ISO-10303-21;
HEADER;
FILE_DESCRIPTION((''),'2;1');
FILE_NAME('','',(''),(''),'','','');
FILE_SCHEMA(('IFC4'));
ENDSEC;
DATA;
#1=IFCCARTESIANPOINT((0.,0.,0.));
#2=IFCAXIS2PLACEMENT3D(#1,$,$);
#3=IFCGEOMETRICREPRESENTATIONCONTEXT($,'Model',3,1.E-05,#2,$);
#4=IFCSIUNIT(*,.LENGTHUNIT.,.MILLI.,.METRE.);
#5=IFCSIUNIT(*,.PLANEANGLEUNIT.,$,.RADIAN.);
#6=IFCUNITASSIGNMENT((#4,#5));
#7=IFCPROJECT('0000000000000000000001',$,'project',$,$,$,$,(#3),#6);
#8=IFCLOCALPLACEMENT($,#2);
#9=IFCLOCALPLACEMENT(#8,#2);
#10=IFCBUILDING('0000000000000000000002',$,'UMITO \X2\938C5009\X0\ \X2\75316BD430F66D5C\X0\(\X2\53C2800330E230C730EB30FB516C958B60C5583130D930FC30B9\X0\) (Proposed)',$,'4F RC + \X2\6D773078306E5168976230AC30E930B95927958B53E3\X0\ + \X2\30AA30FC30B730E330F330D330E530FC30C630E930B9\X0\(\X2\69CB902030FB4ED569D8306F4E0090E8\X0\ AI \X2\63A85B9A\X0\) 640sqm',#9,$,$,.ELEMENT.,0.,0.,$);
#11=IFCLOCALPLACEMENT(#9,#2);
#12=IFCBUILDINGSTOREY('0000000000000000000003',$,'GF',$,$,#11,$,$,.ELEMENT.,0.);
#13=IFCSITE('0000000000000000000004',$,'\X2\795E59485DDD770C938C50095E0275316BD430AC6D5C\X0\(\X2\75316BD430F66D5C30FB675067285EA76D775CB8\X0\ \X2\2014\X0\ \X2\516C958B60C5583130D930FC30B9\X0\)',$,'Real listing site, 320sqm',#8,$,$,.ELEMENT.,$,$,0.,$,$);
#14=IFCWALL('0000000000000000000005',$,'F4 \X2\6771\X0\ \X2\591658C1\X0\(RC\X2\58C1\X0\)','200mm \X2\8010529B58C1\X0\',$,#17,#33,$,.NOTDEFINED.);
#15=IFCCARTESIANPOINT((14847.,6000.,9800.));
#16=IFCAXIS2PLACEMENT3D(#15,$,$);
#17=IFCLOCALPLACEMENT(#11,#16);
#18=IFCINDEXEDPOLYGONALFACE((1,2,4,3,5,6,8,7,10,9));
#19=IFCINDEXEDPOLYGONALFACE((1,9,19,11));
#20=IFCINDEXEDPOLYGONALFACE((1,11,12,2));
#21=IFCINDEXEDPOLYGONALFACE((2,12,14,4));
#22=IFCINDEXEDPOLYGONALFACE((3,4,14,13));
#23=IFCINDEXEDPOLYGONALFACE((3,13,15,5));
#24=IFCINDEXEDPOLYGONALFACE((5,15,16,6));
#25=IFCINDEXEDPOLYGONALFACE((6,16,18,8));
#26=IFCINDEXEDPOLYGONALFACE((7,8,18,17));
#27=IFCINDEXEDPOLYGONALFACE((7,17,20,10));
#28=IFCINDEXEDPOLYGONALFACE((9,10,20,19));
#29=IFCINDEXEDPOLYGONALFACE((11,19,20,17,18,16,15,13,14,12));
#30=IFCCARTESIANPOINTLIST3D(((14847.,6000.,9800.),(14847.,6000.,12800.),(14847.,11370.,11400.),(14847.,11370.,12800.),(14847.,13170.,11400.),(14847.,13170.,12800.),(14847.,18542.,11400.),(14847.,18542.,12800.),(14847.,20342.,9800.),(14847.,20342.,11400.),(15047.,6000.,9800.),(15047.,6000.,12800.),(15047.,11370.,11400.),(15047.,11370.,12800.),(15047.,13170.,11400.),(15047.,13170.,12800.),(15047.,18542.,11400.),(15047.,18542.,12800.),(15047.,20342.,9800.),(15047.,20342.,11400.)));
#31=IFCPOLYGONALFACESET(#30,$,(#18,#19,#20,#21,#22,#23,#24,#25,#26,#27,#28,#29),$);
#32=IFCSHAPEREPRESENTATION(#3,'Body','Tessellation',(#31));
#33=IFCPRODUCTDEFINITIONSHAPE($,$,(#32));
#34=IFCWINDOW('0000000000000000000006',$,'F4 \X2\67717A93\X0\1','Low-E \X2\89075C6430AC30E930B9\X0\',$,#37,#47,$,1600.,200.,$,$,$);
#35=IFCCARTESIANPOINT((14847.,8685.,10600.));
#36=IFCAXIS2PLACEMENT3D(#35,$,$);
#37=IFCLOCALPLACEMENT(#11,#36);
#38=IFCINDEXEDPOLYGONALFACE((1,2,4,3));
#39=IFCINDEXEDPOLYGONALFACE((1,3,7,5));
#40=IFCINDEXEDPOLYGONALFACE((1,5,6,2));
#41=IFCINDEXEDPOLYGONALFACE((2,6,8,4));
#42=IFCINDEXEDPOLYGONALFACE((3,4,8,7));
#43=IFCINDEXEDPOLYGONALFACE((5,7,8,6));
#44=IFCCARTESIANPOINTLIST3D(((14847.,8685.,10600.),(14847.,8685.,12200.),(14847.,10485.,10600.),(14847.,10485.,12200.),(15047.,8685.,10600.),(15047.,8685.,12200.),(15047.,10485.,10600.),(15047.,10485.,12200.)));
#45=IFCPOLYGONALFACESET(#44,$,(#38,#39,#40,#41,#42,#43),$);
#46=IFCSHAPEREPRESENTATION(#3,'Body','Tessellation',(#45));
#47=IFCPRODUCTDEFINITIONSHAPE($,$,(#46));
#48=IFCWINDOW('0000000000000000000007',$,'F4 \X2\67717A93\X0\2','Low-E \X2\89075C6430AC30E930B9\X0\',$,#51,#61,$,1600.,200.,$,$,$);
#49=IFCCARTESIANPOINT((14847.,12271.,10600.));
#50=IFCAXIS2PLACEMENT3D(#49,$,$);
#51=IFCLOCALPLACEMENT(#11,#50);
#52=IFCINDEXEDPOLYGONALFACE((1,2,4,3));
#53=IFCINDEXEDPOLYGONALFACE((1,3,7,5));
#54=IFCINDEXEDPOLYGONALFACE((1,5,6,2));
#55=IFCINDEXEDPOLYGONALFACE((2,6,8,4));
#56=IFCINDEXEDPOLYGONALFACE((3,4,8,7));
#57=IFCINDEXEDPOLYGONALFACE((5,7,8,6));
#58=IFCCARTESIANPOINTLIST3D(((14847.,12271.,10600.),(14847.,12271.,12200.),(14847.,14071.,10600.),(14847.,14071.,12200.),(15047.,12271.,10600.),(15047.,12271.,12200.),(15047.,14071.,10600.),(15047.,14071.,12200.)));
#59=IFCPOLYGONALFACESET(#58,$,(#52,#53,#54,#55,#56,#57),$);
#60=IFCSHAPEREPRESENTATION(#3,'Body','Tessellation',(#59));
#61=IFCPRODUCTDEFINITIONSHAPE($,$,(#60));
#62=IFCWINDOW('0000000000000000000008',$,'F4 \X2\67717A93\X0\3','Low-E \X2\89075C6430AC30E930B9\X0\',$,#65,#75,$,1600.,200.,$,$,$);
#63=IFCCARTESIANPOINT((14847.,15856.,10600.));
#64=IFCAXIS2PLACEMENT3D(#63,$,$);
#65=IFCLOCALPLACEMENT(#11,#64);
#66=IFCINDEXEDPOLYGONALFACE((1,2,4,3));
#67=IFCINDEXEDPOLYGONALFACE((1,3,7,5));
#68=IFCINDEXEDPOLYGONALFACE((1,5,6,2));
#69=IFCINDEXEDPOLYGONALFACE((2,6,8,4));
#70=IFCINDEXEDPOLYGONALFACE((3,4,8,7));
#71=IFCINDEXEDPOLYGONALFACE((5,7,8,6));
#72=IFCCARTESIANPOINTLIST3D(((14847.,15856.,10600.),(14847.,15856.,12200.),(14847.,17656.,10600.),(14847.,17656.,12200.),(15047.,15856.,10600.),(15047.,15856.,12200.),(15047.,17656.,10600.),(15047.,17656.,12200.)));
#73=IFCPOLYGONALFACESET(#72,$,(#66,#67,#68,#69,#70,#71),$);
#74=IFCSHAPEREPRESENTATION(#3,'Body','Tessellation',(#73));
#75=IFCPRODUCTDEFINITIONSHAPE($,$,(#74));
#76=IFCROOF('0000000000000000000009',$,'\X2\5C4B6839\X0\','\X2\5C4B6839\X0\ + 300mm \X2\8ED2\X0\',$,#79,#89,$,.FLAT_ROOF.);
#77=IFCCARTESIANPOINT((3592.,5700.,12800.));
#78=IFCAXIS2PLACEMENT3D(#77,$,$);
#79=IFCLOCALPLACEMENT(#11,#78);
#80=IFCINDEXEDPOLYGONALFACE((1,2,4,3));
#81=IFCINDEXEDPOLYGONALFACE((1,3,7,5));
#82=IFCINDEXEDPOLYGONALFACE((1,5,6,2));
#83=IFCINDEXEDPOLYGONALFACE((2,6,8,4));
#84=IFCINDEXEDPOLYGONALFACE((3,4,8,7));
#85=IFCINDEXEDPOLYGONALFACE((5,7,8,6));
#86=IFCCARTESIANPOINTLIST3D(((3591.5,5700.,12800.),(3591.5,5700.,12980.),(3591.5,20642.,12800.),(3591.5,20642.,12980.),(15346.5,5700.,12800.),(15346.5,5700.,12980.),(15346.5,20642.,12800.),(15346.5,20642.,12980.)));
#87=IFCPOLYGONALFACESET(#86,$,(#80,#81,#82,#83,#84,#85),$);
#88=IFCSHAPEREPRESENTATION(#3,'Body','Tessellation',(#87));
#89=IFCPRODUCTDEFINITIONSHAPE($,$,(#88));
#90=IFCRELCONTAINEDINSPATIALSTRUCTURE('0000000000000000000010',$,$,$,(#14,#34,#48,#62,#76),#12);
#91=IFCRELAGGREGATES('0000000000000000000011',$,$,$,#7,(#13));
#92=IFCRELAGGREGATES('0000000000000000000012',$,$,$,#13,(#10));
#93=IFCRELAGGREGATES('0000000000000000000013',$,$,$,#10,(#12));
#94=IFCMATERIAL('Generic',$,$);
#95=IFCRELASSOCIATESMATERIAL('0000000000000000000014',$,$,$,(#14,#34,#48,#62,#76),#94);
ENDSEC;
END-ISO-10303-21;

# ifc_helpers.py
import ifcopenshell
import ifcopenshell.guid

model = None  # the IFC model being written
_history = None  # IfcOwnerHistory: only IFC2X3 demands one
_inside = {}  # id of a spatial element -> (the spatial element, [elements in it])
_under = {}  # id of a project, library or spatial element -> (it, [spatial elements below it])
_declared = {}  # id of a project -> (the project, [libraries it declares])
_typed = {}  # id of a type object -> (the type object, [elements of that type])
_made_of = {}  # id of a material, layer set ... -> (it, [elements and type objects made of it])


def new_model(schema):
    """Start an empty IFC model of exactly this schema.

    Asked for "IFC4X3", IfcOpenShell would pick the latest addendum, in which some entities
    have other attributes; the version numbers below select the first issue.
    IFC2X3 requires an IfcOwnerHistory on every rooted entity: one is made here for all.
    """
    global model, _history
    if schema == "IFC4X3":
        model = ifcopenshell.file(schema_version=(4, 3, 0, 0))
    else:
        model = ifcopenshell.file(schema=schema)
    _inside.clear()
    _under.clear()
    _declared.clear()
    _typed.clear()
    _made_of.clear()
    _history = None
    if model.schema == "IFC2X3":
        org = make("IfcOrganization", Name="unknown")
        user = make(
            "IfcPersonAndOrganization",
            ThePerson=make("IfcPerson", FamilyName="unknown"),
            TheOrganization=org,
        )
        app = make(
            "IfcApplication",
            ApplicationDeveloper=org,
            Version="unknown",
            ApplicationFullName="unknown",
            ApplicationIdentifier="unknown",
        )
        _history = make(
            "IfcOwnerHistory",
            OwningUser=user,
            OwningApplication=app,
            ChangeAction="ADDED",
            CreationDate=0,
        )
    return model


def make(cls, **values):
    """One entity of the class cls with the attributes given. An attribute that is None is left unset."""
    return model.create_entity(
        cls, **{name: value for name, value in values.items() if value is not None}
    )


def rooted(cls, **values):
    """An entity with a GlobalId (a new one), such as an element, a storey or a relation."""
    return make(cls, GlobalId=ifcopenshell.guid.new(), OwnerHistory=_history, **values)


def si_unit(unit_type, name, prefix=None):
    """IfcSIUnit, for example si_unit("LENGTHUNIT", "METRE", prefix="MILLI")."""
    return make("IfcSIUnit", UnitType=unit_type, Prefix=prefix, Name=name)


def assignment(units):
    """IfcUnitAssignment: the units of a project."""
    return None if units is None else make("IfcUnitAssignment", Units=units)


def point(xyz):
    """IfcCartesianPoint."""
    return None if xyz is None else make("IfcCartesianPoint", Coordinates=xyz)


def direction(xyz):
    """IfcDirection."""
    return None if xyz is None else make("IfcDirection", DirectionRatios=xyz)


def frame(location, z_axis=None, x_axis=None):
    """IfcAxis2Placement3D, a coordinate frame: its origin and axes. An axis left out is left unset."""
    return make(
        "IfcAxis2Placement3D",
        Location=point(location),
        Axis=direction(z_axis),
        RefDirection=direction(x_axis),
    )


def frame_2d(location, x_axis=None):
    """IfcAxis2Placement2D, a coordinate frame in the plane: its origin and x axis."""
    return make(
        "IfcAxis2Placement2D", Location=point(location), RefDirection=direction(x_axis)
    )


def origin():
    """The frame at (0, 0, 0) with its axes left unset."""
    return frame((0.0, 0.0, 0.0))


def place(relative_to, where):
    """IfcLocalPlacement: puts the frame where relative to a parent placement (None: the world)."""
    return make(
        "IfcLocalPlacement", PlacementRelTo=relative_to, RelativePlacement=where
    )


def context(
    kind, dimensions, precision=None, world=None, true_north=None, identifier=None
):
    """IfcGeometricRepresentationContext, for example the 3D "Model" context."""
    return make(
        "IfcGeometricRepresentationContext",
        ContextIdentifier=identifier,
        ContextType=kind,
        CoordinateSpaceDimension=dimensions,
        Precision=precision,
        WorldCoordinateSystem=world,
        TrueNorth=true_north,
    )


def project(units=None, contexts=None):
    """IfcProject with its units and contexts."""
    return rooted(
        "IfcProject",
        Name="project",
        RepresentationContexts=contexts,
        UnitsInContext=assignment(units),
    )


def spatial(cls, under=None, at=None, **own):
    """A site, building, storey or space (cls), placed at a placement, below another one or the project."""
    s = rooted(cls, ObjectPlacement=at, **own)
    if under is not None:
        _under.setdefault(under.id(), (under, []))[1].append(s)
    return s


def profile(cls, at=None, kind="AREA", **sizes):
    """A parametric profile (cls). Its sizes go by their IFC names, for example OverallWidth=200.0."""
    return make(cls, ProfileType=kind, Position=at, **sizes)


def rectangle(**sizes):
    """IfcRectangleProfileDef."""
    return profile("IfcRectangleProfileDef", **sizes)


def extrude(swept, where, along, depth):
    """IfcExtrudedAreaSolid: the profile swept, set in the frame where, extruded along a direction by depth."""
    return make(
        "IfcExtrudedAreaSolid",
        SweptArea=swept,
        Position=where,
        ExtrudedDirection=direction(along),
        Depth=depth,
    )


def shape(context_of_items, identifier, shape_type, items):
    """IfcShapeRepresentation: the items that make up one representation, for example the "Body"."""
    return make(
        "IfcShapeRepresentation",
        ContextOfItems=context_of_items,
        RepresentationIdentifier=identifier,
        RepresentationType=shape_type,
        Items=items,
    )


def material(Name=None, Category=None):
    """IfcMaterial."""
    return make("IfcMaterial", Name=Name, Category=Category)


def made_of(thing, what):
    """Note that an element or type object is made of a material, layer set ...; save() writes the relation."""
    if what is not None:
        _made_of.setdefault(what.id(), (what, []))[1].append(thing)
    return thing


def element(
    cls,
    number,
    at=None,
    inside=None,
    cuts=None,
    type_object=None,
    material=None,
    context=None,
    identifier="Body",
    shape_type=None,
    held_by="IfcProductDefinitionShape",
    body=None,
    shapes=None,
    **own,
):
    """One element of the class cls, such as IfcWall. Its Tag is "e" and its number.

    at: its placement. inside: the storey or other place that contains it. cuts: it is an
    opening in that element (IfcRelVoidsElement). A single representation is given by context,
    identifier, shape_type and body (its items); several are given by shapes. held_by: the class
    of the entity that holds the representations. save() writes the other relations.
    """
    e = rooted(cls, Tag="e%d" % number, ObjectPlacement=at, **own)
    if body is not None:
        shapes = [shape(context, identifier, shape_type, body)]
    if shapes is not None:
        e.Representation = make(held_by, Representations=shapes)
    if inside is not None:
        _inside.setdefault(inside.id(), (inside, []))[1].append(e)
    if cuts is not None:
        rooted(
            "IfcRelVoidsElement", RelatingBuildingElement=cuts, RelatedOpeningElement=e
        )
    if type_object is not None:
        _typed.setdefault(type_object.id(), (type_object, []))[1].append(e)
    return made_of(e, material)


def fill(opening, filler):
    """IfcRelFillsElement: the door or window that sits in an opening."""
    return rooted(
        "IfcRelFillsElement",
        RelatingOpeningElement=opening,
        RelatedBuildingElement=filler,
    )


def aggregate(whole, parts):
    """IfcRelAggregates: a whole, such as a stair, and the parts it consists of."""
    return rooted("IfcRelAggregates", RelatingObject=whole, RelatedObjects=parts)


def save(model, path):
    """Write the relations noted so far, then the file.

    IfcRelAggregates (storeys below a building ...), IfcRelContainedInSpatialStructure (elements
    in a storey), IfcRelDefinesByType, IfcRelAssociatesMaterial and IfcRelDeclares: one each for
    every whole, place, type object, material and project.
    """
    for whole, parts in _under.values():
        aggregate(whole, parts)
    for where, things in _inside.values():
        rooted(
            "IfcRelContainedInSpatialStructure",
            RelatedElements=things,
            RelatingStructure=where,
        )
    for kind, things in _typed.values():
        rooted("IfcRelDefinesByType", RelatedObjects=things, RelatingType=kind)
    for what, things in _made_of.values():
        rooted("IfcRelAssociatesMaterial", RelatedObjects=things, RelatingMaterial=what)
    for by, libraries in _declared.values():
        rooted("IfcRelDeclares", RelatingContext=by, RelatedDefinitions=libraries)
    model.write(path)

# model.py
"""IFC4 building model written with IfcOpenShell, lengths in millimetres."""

from ifc_helpers import new_model, si_unit, frame, frame_2d, origin, place, context, project, spatial, rectangle, extrude, material, element, fill, save


model = new_model("IFC4")

# Units and contexts
model_context = context("Model", 3, precision=1e-05, world=origin())
ifc_project = project(units=[si_unit("LENGTHUNIT", "METRE", prefix="MILLI"), si_unit("PLANEANGLEUNIT", "RADIAN")], contexts=[model_context])

# Site, building, storey
site_placement = place(None, origin())
site = spatial("IfcSite", under=ifc_project, at=site_placement, Name="神奈川県鎌倉市由比ガ浜(由比ヶ浜・材木座海岸 — 公開情報ベース)", ObjectType="Real listing site, 320sqm", CompositionType="ELEMENT", RefElevation=0.0)
building_placement = place(site_placement, origin())
building = spatial("IfcBuilding", under=site, at=building_placement, Name="UMITO 鎌倉 由比ヶ浜(参考モデル・公開情報ベース) (Proposed)", ObjectType="4F RC + 海への全面ガラス大開口 + オーシャンビューテラス(構造・仕様は一部 AI 推定) 640sqm", CompositionType="ELEMENT", ElevationOfRefHeight=0.0, ElevationOfTerrain=0.0)
storey_placement = place(building_placement, origin())
storey = spatial("IfcBuildingStorey", under=building, at=storey_placement, Name="GF", CompositionType="ELEMENT", Elevation=0.0)

# Shared definitions
ifc_material_1 = material(Name="Generic")

# Wall, openings, windows
wall_1_placement = place(storey_placement, frame((14847.0, 6000.0, 9800.0)))
wall_1 = element("IfcWall", 1, at=wall_1_placement, inside=storey, material=ifc_material_1, Name="F4 東 外壁(RC壁)", Description="200mm 耐力壁", PredefinedType="NOTDEFINED", context=model_context, shape_type="SweptSolid", body=[
    extrude(rectangle(XDim=200.0, YDim=14342.0, at=frame_2d((100.0, 7171.0))), frame((14847.0, 6000.0, 9800.0)), (0.0, 0.0, 1.0), 3000.0),
])
opening_1_placement = place(storey_placement, frame((14847.0, 8685.0, 10600.0)))
opening_1 = element("IfcOpeningElement", 2, at=opening_1_placement, cuts=wall_1, PredefinedType="NOTDEFINED", context=model_context, shape_type="SweptSolid", body=[
    extrude(rectangle(XDim=200.0, YDim=1800.0, at=frame_2d((100.0, 900.0))), frame((14847.0, 8685.0, 10600.0)), (0.0, 0.0, 1.0), 1600.0),
])
opening_2_placement = place(storey_placement, frame((14847.0, 12271.0, 10600.0)))
opening_2 = element("IfcOpeningElement", 3, at=opening_2_placement, cuts=wall_1, PredefinedType="NOTDEFINED", context=model_context, shape_type="SweptSolid", body=[
    extrude(rectangle(XDim=200.0, YDim=1800.0, at=frame_2d((100.0, 900.0))), frame((14847.0, 12271.0, 10600.0)), (0.0, 0.0, 1.0), 1600.0),
])
opening_3_placement = place(storey_placement, frame((14847.0, 15856.0, 10600.0)))
opening_3 = element("IfcOpeningElement", 4, at=opening_3_placement, cuts=wall_1, PredefinedType="NOTDEFINED", context=model_context, shape_type="SweptSolid", body=[
    extrude(rectangle(XDim=200.0, YDim=1800.0, at=frame_2d((100.0, 900.0))), frame((14847.0, 15856.0, 10600.0)), (0.0, 0.0, 1.0), 1600.0),
])
window_1_placement = place(storey_placement, frame((14847.0, 8685.0, 10600.0)))
window_1 = element("IfcWindow", 5, at=window_1_placement, inside=storey, material=ifc_material_1, Name="F4 東窓1", Description="Low-E 複層ガラス", OverallHeight=1600.0, OverallWidth=200.0, context=model_context, shape_type="SweptSolid", body=[
    extrude(rectangle(XDim=200.0, YDim=1800.0, at=frame_2d((100.0, 900.0))), frame((14847.0, 8685.0, 10600.0)), (0.0, 0.0, 1.0), 1600.0),
])
fill(opening_1, window_1)
window_2_placement = place(storey_placement, frame((14847.0, 12271.0, 10600.0)))
window_2 = element("IfcWindow", 6, at=window_2_placement, inside=storey, material=ifc_material_1, Name="F4 東窓2", Description="Low-E 複層ガラス", OverallHeight=1600.0, OverallWidth=200.0, context=model_context, shape_type="SweptSolid", body=[
    extrude(rectangle(XDim=200.0, YDim=1800.0, at=frame_2d((100.0, 900.0))), frame((14847.0, 12271.0, 10600.0)), (0.0, 0.0, 1.0), 1600.0),
])
fill(opening_2, window_2)
window_3_placement = place(storey_placement, frame((14847.0, 15856.0, 10600.0)))
window_3 = element("IfcWindow", 7, at=window_3_placement, inside=storey, material=ifc_material_1, Name="F4 東窓3", Description="Low-E 複層ガラス", OverallHeight=1600.0, OverallWidth=200.0, context=model_context, shape_type="SweptSolid", body=[
    extrude(rectangle(XDim=200.0, YDim=1800.0, at=frame_2d((100.0, 900.0))), frame((14847.0, 15856.0, 10600.0)), (0.0, 0.0, 1.0), 1600.0),
])
fill(opening_3, window_3)

# Roof
roof_placement = place(storey_placement, frame((3592.0, 5700.0, 12800.0)))
element("IfcRoof", 8, at=roof_placement, inside=storey, material=ifc_material_1, Name="屋根", Description="屋根 + 300mm 軒", PredefinedType="FLAT_ROOF", context=model_context, shape_type="SweptSolid", body=[
    extrude(rectangle(XDim=11755.0, YDim=14942.0, at=frame_2d((5877.0, 7471.0))), frame((3592.0, 5700.0, 12800.0)), (0.0, 0.0, 1.0), 180.0),
])

save(model, "model.ifc")
